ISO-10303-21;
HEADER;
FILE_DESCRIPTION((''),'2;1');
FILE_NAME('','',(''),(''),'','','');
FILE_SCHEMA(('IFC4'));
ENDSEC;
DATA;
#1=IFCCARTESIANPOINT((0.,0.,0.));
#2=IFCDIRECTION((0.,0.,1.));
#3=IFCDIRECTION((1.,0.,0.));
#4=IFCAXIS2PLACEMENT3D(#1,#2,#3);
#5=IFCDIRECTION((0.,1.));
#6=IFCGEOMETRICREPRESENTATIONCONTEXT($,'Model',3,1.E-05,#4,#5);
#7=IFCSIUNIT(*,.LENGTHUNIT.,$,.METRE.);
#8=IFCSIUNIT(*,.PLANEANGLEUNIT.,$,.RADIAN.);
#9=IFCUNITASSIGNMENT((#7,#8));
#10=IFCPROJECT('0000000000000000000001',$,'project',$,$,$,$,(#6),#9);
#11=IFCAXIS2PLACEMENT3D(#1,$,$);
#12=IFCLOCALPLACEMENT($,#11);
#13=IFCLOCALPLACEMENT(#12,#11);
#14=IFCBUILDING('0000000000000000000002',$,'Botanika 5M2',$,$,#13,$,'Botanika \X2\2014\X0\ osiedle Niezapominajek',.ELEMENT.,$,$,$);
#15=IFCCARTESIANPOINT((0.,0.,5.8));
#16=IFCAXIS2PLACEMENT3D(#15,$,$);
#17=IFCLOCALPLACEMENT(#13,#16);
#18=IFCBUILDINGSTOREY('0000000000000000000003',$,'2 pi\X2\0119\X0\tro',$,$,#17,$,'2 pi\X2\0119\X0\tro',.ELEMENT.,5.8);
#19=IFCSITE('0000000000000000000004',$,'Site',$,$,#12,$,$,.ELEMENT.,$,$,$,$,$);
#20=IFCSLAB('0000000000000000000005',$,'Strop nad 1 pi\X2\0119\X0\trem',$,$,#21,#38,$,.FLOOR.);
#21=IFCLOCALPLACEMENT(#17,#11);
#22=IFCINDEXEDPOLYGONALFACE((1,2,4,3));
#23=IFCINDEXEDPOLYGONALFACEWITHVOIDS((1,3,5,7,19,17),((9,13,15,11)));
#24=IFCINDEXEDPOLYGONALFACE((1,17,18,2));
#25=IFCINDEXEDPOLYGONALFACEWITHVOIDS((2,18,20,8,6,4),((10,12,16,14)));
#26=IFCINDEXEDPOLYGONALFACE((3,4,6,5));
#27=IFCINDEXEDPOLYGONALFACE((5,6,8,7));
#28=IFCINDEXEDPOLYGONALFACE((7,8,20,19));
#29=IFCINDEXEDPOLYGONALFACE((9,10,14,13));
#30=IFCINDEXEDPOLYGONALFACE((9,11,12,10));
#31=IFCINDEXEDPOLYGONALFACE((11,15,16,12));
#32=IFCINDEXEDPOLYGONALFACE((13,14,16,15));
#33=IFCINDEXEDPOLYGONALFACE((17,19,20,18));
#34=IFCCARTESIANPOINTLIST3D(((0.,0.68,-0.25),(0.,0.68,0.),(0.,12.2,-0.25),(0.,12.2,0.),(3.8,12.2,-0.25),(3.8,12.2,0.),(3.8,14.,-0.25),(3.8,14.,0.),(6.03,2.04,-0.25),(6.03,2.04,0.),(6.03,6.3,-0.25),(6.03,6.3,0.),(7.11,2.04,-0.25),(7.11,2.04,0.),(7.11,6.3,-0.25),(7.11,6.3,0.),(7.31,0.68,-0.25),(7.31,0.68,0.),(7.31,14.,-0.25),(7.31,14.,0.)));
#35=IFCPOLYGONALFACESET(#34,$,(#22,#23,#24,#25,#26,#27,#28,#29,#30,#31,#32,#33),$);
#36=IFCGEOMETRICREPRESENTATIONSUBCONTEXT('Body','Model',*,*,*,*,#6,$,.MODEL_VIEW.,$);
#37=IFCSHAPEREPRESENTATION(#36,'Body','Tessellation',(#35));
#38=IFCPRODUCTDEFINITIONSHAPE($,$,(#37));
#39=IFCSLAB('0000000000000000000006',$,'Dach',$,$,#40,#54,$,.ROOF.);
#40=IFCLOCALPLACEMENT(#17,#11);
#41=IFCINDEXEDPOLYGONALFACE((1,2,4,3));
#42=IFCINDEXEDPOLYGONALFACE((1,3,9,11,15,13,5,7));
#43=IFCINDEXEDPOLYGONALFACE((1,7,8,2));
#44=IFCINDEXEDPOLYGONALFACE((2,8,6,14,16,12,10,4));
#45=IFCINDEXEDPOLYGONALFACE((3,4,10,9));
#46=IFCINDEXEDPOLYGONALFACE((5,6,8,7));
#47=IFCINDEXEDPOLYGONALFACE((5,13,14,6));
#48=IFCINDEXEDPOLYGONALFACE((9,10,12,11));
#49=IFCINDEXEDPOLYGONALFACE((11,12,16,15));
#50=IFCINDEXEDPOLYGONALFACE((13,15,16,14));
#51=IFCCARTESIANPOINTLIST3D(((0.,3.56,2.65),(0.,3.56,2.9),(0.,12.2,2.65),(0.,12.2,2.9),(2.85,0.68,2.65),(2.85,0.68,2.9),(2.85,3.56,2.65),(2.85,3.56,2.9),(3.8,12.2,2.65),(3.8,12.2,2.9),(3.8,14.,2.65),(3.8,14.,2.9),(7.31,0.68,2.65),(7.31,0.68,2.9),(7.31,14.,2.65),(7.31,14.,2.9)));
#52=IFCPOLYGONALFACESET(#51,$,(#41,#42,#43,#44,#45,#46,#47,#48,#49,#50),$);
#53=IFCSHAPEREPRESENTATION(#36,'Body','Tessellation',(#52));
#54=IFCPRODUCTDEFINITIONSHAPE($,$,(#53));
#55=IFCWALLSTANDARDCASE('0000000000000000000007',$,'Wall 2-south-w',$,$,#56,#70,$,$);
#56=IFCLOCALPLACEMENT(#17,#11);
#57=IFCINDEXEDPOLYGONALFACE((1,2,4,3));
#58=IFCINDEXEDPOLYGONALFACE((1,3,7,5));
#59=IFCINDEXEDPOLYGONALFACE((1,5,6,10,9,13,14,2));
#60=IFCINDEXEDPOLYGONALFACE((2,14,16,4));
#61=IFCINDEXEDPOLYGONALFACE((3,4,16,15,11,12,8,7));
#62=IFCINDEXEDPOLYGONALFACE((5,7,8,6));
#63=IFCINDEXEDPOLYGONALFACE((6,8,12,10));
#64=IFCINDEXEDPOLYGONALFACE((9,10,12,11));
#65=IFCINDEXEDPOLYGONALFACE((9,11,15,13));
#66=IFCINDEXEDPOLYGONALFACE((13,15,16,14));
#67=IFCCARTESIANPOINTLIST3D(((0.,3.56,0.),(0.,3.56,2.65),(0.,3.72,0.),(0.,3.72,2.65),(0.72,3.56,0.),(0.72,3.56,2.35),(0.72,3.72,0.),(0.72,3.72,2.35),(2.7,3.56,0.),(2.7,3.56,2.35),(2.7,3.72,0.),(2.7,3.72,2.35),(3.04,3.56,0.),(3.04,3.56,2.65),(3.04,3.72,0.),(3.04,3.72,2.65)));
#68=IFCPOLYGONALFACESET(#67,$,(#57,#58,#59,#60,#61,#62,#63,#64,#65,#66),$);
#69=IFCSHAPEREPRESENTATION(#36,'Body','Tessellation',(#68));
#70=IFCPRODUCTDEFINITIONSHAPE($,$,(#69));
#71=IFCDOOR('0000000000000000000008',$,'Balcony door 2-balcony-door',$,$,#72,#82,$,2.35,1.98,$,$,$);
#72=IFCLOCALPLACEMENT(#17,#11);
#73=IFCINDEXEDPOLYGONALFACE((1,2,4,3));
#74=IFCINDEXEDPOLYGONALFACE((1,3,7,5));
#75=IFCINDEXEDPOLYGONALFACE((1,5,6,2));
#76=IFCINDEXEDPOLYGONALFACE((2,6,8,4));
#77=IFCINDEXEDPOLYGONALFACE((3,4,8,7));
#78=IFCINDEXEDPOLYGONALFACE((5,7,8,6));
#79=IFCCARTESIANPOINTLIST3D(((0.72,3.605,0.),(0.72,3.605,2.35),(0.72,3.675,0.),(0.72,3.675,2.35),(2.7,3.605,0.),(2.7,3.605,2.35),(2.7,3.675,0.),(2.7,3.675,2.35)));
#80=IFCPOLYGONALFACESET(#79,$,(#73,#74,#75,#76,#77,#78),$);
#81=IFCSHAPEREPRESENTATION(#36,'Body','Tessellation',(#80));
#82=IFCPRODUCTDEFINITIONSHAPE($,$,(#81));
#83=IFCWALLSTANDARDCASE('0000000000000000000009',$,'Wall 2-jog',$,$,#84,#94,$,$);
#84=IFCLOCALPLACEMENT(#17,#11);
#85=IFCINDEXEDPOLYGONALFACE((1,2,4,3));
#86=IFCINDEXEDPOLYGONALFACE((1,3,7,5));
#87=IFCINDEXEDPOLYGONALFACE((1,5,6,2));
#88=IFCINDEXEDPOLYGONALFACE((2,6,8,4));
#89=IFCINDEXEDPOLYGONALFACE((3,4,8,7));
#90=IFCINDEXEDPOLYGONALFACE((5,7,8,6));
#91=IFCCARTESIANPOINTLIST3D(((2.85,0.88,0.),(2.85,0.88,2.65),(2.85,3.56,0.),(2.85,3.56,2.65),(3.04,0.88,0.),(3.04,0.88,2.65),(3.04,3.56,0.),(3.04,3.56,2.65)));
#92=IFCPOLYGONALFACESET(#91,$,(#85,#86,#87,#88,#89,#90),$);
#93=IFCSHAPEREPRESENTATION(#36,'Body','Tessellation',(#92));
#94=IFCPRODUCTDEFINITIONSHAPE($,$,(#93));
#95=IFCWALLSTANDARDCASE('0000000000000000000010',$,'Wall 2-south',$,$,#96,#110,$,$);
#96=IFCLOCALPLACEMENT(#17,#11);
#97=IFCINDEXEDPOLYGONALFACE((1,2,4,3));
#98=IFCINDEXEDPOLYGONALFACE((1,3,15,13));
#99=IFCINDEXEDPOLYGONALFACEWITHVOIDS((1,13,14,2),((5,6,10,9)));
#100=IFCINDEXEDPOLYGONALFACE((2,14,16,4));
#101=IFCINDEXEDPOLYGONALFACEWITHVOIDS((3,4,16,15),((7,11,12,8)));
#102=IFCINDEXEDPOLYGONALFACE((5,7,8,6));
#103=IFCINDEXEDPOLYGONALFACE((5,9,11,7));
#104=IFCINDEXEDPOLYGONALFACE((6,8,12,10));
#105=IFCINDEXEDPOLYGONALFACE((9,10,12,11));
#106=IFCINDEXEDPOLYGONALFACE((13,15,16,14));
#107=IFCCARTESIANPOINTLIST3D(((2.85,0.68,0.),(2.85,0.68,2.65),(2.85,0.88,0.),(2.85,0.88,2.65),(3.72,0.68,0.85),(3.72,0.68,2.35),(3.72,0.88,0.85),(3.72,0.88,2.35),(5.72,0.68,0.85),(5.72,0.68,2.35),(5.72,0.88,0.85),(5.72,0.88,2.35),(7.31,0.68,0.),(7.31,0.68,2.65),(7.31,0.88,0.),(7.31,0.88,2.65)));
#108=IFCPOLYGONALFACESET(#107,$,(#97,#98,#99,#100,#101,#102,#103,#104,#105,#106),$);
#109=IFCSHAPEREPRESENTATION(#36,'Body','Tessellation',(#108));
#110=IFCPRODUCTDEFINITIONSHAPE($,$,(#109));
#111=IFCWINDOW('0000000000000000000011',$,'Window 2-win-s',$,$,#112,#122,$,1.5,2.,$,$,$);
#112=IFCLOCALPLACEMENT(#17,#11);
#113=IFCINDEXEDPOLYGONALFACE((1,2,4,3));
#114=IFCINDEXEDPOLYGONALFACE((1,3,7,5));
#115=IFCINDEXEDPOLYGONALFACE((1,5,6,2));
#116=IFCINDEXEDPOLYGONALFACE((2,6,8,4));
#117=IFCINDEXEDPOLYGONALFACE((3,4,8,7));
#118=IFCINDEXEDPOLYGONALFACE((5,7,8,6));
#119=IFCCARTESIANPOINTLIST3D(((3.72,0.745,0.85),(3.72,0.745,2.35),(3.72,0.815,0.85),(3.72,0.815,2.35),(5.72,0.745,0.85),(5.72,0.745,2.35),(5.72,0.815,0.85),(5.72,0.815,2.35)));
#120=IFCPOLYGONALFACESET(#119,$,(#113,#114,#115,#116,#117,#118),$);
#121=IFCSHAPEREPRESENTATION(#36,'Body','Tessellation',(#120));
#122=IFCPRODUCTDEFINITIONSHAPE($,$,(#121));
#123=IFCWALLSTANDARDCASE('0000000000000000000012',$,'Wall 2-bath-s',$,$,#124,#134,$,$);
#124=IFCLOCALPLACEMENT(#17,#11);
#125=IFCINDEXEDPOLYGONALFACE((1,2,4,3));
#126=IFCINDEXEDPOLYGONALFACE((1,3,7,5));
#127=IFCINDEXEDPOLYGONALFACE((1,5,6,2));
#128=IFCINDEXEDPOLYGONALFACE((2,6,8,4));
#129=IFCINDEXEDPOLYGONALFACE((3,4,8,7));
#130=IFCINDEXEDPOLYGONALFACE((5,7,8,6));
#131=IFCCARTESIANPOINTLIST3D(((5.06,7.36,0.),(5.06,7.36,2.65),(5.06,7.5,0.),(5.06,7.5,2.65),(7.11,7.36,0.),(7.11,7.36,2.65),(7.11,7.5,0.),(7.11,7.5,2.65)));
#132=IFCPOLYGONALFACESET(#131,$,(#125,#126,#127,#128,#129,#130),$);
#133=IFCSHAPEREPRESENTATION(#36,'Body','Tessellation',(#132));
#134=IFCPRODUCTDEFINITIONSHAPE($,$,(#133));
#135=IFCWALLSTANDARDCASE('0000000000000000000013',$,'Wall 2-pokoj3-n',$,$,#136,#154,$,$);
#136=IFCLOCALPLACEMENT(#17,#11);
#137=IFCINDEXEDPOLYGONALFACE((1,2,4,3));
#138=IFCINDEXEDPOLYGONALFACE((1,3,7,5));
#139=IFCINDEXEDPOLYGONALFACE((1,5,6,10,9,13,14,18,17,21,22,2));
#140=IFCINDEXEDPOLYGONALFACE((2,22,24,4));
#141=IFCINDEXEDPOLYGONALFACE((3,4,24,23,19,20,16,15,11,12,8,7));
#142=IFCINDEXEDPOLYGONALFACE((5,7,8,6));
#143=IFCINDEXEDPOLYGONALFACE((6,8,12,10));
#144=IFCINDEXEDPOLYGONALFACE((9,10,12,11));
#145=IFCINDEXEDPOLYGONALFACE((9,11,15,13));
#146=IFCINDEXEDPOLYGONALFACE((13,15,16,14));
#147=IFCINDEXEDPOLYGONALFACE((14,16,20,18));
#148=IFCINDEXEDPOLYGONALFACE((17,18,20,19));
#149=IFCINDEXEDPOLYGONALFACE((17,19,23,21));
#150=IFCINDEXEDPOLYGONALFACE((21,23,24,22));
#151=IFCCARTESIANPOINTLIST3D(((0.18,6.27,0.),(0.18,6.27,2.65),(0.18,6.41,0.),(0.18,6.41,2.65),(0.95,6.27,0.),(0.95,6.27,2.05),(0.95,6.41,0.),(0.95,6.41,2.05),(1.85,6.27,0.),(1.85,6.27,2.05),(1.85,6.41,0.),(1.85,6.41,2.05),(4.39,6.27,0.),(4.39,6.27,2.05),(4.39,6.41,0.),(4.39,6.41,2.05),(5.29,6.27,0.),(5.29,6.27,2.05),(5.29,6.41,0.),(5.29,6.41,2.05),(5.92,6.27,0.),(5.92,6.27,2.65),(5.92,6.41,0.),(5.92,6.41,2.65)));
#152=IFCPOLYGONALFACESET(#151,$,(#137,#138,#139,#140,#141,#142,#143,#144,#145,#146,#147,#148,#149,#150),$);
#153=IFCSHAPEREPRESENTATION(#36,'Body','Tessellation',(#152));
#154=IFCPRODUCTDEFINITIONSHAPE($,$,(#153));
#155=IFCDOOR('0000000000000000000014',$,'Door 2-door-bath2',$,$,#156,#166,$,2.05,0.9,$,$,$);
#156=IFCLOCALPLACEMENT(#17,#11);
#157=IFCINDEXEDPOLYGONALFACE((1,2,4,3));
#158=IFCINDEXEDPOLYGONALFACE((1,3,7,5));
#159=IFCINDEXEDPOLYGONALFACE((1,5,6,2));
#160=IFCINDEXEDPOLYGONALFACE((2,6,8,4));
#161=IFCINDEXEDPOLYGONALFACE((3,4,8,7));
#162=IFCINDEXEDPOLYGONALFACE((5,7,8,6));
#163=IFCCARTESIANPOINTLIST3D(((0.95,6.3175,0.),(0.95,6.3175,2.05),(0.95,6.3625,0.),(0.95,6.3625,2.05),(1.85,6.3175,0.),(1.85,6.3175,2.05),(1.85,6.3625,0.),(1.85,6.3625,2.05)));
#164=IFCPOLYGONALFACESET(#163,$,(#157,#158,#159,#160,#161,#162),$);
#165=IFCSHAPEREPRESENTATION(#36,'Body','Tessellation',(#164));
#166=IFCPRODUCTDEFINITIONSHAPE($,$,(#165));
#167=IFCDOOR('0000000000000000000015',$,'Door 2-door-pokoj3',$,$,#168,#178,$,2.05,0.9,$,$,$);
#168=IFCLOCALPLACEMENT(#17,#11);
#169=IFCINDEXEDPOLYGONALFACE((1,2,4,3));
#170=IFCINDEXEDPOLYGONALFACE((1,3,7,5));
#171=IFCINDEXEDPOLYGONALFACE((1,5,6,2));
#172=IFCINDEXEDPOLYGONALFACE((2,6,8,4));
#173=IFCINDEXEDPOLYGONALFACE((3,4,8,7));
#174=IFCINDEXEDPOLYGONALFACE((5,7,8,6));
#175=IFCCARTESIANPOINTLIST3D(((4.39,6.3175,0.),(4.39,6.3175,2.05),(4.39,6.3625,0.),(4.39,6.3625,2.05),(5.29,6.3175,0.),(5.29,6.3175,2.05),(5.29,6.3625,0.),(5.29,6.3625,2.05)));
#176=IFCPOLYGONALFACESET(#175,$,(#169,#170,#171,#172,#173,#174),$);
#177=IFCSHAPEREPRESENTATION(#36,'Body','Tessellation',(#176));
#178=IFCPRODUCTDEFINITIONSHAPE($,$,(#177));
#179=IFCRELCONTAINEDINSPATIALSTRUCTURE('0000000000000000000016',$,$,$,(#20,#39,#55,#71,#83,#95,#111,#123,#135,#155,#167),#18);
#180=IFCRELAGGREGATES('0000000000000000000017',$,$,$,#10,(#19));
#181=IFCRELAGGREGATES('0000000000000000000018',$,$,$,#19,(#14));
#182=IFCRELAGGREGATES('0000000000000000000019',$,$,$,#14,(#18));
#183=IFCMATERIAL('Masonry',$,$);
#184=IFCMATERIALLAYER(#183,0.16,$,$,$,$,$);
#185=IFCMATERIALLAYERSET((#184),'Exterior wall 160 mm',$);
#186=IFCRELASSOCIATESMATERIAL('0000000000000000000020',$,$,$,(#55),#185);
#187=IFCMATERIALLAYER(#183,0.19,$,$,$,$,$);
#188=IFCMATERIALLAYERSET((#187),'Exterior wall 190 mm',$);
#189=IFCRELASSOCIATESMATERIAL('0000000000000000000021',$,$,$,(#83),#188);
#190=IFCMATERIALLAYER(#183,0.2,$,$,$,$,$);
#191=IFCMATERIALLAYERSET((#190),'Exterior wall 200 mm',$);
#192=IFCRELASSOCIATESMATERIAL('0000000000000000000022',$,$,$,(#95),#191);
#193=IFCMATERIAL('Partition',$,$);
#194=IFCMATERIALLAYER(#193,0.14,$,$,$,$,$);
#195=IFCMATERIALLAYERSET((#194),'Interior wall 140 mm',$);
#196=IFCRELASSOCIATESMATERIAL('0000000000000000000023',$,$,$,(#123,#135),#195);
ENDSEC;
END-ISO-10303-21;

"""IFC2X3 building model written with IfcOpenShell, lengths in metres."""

from ifc_helpers import new_model, si_unit, direction, frame, frame_2d, origin, origin_with_axes, place, context, subcontext, project, spatial, polyline, rectangle, outline, extrude, material, layer, layer_set, layer_usage, element, fill, save


model = new_model("IFC2X3")

# Units and contexts
model_context = context("Model", 3, precision=1e-05, world=origin_with_axes(), true_north=direction((0.0, 1.0)))
body_context = subcontext(model_context, "Body", "Model", "MODEL_VIEW")
ifc_project = project(units=[si_unit("LENGTHUNIT", "METRE"), si_unit("PLANEANGLEUNIT", "RADIAN")], contexts=[model_context])

# Site, building, storey
site_placement = place(None, origin())
site = spatial("IfcSite", under=ifc_project, at=site_placement, Name="Site", CompositionType="ELEMENT")
building_placement = place(site_placement, origin())
building = spatial("IfcBuilding", under=site, at=building_placement, Name="Botanika 5M2", LongName="Botanika — osiedle Niezapominajek", CompositionType="ELEMENT")
storey_placement = place(building_placement, frame((0.0, 0.0, 5.8)))
storey = spatial("IfcBuildingStorey", under=building, at=storey_placement, Name="2 piętro", LongName="2 piętro", CompositionType="ELEMENT", Elevation=5.8)

# Slabs
slab_1_placement = place(storey_placement, frame((0.0, 0.0, -0.25)))
element("IfcSlab", 1, at=slab_1_placement, inside=storey, Name="Strop nad 1 piętrem", PredefinedType="FLOOR", context=body_context, shape_type="SweptSolid", body=[
    extrude(outline(polyline([(3.8, 14.0), (7.31, 14.0), (7.31, 0.68), (0.0, 0.68), (0.0, 12.2), (3.8, 12.2), (3.8, 14.0)]), holes=[polyline([(6.03, 6.3), (7.11, 6.3), (7.11, 2.04), (6.03, 2.04), (6.03, 6.3)])]), origin_with_axes(), (0.0, 0.0, 1.0), 0.25),
])
slab_2_placement = place(storey_placement, frame((0.0, 0.0, 2.65)))
element("IfcSlab", 2, at=slab_2_placement, inside=storey, Name="Dach", PredefinedType="ROOF", context=body_context, shape_type="SweptSolid", body=[
    extrude(outline(polyline([(3.8, 14.0), (7.31, 14.0), (7.31, 0.68), (2.85, 0.68), (2.85, 3.56), (0.0, 3.56), (0.0, 12.2), (3.8, 12.2), (3.8, 14.0)])), origin_with_axes(), (0.0, 0.0, 1.0), 0.25),
])

# Wall, opening, door
ifc_material_1 = material(Name="Masonry")
ifc_layer_1 = layer(ifc_material_1, 0.16)
ifc_layer_set_1 = layer_set([ifc_layer_1], Name="Exterior wall 160 mm")
ifc_layer_usage_1 = layer_usage(ifc_layer_set_1, "AXIS2", "POSITIVE", -0.08)
wall_1_placement = place(storey_placement, frame((0.0, 3.64, 0.0)))
wall_1 = element("IfcWallStandardCase", 3, at=wall_1_placement, inside=storey, material=ifc_layer_usage_1, Name="Wall 2-south-w", context=body_context, shape_type="SweptSolid", body=[
    extrude(rectangle(XDim=3.04, YDim=0.16, at=frame_2d((1.52, 0.0))), origin_with_axes(), (0.0, 0.0, 1.0), 2.65),
])
opening_1_placement = place(wall_1_placement, frame((0.72, 0.13, 0.0), z_axis=(0.0, -1.0, 0.0), x_axis=(1.0, 0.0, 0.0)))
opening_1 = element("IfcOpeningElement", 4, at=opening_1_placement, cuts=wall_1, context=body_context, shape_type="SweptSolid", body=[
    extrude(rectangle(XDim=1.98, YDim=2.35, at=frame_2d((0.99, 1.175))), origin_with_axes(), (0.0, 0.0, 1.0), 0.26),
])
door_1_placement = place(wall_1_placement, frame((0.72, 0.0, 0.0)))
door_1 = element("IfcDoor", 5, at=door_1_placement, inside=storey, Name="Balcony door 2-balcony-door", OverallHeight=2.35, OverallWidth=1.98, context=body_context, shape_type="SweptSolid", body=[
    extrude(rectangle(XDim=1.98, YDim=0.07, at=frame_2d((0.99, 0.0))), origin_with_axes(), (0.0, 0.0, 1.0), 2.35),
])
fill(opening_1, door_1)

# Wall
ifc_layer_2 = layer(ifc_material_1, 0.19)
ifc_layer_set_2 = layer_set([ifc_layer_2], Name="Exterior wall 190 mm")
ifc_layer_usage_2 = layer_usage(ifc_layer_set_2, "AXIS2", "POSITIVE", -0.095)
wall_2_placement = place(storey_placement, frame((2.945, 3.56, 0.0), z_axis=(0.0, 0.0, 1.0), x_axis=(0.0, -1.0, 0.0)))
element("IfcWallStandardCase", 6, at=wall_2_placement, inside=storey, material=ifc_layer_usage_2, Name="Wall 2-jog", context=body_context, shape_type="SweptSolid", body=[
    extrude(rectangle(XDim=2.68, YDim=0.19, at=frame_2d((1.34, 0.0))), origin_with_axes(), (0.0, 0.0, 1.0), 2.65),
])

# Wall, opening, window
ifc_layer_3 = layer(ifc_material_1, 0.2)
ifc_layer_set_3 = layer_set([ifc_layer_3], Name="Exterior wall 200 mm")
ifc_layer_usage_3 = layer_usage(ifc_layer_set_3, "AXIS2", "POSITIVE", -0.1)
wall_3_placement = place(storey_placement, frame((2.85, 0.78, 0.0)))
wall_3 = element("IfcWallStandardCase", 7, at=wall_3_placement, inside=storey, material=ifc_layer_usage_3, Name="Wall 2-south", context=body_context, shape_type="SweptSolid", body=[
    extrude(rectangle(XDim=4.46, YDim=0.2, at=frame_2d((2.23, 0.0))), origin_with_axes(), (0.0, 0.0, 1.0), 2.65),
])
opening_2_placement = place(wall_3_placement, frame((0.87, 0.15, 0.85), z_axis=(0.0, -1.0, 0.0), x_axis=(1.0, 0.0, 0.0)))
opening_2 = element("IfcOpeningElement", 8, at=opening_2_placement, cuts=wall_3, context=body_context, shape_type="SweptSolid", body=[
    extrude(rectangle(XDim=2.0, YDim=1.5, at=frame_2d((1.0, 0.75))), origin_with_axes(), (0.0, 0.0, 1.0), 0.3),
])
window_placement = place(wall_3_placement, frame((0.87, 0.0, 0.85)))
window = element("IfcWindow", 9, at=window_placement, inside=storey, Name="Window 2-win-s", OverallHeight=1.5, OverallWidth=2.0, context=body_context, shape_type="SweptSolid", body=[
    extrude(rectangle(XDim=2.0, YDim=0.07, at=frame_2d((1.0, 0.0))), origin_with_axes(), (0.0, 0.0, 1.0), 1.5),
])
fill(opening_2, window)

# Wall
ifc_material_2 = material(Name="Partition")
ifc_layer_4 = layer(ifc_material_2, 0.14)
ifc_layer_set_4 = layer_set([ifc_layer_4], Name="Interior wall 140 mm")
ifc_layer_usage_4 = layer_usage(ifc_layer_set_4, "AXIS2", "POSITIVE", -0.07)
wall_4_placement = place(storey_placement, frame((5.06, 7.43, 0.0)))
element("IfcWallStandardCase", 10, at=wall_4_placement, inside=storey, material=ifc_layer_usage_4, Name="Wall 2-bath-s", context=body_context, shape_type="SweptSolid", body=[
    extrude(rectangle(XDim=2.05, YDim=0.14, at=frame_2d((1.025, 0.0))), origin_with_axes(), (0.0, 0.0, 1.0), 2.65),
])

# Wall, openings, doors
wall_5_placement = place(storey_placement, frame((0.18, 6.34, 0.0)))
wall_5 = element("IfcWallStandardCase", 11, at=wall_5_placement, inside=storey, material=ifc_layer_usage_4, Name="Wall 2-pokoj3-n", context=body_context, shape_type="SweptSolid", body=[
    extrude(rectangle(XDim=5.74, YDim=0.14, at=frame_2d((2.87, 0.0))), origin_with_axes(), (0.0, 0.0, 1.0), 2.65),
])
opening_3_placement = place(wall_5_placement, frame((0.77, 0.12, 0.0), z_axis=(0.0, -1.0, 0.0), x_axis=(1.0, 0.0, 0.0)))
opening_3 = element("IfcOpeningElement", 12, at=opening_3_placement, cuts=wall_5, context=body_context, shape_type="SweptSolid", body=[
    extrude(rectangle(XDim=0.9, YDim=2.05, at=frame_2d((0.45, 1.025))), origin_with_axes(), (0.0, 0.0, 1.0), 0.24),
])
opening_4_placement = place(wall_5_placement, frame((4.21, 0.12, 0.0), z_axis=(0.0, -1.0, 0.0), x_axis=(1.0, 0.0, 0.0)))
opening_4 = element("IfcOpeningElement", 13, at=opening_4_placement, cuts=wall_5, context=body_context, shape_type="SweptSolid", body=[
    extrude(rectangle(XDim=0.9, YDim=2.05, at=frame_2d((0.45, 1.025))), origin_with_axes(), (0.0, 0.0, 1.0), 0.24),
])
door_2_placement = place(wall_5_placement, frame((0.77, 0.0, 0.0)))
door_2 = element("IfcDoor", 14, at=door_2_placement, inside=storey, Name="Door 2-door-bath2", OverallHeight=2.05, OverallWidth=0.9, context=body_context, shape_type="SweptSolid", body=[
    extrude(rectangle(XDim=0.9, YDim=0.045, at=frame_2d((0.45, 0.0))), origin_with_axes(), (0.0, 0.0, 1.0), 2.05),
])
fill(opening_3, door_2)
door_3_placement = place(wall_5_placement, frame((4.21, 0.0, 0.0)))
door_3 = element("IfcDoor", 15, at=door_3_placement, inside=storey, Name="Door 2-door-pokoj3", OverallHeight=2.05, OverallWidth=0.9, context=body_context, shape_type="SweptSolid", body=[
    extrude(rectangle(XDim=0.9, YDim=0.045, at=frame_2d((0.45, 0.0))), origin_with_axes(), (0.0, 0.0, 1.0), 2.05),
])
fill(opening_4, door_3)

save(model, "model.ifc")
